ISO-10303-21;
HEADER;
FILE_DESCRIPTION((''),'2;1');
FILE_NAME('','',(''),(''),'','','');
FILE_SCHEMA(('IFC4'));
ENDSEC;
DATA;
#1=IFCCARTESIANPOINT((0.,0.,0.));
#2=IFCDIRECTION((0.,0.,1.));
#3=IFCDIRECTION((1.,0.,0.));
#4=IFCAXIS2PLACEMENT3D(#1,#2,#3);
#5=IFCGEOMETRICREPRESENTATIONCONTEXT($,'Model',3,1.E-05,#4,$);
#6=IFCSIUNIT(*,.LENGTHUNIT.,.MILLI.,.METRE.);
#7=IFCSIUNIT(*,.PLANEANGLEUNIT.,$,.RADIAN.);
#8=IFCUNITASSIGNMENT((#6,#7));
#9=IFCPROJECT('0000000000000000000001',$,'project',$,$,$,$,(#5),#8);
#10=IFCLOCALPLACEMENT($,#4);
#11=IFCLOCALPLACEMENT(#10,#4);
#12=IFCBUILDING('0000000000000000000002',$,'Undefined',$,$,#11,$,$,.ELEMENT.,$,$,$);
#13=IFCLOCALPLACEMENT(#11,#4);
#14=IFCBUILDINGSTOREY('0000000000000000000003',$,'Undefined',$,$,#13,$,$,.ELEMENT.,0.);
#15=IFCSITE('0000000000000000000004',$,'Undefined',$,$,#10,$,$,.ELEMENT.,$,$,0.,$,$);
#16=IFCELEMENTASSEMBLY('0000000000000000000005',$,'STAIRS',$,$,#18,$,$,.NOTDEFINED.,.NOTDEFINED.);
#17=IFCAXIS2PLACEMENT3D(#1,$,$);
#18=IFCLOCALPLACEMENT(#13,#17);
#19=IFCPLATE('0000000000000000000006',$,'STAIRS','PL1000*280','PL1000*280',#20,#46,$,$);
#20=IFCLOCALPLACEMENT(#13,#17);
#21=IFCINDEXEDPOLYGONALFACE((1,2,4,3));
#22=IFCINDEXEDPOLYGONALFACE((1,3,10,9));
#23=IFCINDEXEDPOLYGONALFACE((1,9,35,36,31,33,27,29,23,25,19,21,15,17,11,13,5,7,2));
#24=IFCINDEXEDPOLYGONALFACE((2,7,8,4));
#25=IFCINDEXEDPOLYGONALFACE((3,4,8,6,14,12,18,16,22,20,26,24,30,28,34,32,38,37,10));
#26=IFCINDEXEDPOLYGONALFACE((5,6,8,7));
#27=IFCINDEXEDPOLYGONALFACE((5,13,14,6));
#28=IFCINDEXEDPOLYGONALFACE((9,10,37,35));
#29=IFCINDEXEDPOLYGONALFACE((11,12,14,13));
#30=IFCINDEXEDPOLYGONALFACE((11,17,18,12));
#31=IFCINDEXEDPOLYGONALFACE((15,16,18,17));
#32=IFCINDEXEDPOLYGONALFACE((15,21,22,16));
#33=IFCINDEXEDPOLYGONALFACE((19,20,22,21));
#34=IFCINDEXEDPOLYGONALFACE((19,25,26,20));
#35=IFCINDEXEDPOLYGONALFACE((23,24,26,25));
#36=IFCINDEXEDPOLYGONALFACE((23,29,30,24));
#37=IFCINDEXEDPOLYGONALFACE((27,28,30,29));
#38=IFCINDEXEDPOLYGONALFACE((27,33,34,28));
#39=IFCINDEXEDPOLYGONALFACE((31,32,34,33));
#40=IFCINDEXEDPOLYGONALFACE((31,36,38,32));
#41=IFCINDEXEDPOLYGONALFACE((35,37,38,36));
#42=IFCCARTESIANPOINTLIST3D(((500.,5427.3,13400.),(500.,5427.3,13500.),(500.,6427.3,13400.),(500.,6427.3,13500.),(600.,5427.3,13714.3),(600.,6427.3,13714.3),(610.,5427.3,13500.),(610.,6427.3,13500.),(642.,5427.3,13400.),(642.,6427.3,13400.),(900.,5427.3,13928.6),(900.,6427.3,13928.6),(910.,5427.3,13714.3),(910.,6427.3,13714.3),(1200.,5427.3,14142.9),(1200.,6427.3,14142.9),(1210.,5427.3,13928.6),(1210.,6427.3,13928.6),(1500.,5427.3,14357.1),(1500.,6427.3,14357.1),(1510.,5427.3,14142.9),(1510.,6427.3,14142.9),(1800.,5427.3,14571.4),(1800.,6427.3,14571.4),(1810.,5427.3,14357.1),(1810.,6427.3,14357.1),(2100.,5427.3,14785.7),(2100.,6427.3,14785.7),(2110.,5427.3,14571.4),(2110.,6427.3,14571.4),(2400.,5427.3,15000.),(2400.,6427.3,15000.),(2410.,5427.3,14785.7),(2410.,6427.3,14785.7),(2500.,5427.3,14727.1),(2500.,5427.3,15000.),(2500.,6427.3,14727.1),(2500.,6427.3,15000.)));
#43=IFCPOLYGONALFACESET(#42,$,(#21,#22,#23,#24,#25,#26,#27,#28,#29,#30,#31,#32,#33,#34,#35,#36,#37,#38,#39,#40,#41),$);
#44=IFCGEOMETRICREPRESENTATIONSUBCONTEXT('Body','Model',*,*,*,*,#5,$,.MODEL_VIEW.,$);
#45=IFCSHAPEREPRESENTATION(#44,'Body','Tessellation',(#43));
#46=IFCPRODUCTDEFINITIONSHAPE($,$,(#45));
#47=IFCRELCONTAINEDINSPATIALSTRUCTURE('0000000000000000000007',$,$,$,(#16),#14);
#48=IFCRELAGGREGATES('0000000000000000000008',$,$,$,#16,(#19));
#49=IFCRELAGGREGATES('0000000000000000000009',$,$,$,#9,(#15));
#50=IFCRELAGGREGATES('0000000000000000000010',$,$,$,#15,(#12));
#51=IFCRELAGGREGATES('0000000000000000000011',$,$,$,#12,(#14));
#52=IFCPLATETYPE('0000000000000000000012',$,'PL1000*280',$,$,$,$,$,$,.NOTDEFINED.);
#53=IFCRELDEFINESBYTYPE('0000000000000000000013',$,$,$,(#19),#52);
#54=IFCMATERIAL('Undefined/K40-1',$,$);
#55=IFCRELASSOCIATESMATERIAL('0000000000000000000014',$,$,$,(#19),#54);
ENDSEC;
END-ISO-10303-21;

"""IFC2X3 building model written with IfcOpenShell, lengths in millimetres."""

from ifc_helpers import new_model, si_unit, frame, origin_with_axes, place, context, subcontext, project, spatial, polyline, outline, extrude, material, type_object, element, aggregate, save


model = new_model("IFC2X3")

# Units and contexts
model_context = context("Model", 3, precision=1e-05, world=origin_with_axes())
body_context = subcontext(model_context, "Body", "Model", "MODEL_VIEW")
ifc_project = project(units=[si_unit("LENGTHUNIT", "METRE", prefix="MILLI"), si_unit("PLANEANGLEUNIT", "RADIAN")], contexts=[model_context])

# Site, building, storey
site_placement = place(None, origin_with_axes())
site = spatial("IfcSite", under=ifc_project, at=site_placement, Name="Undefined", CompositionType="ELEMENT", RefElevation=0.0)
building_placement = place(site_placement, origin_with_axes())
building = spatial("IfcBuilding", under=site, at=building_placement, Name="Undefined", CompositionType="ELEMENT")
storey_placement = place(building_placement, origin_with_axes())
storey = spatial("IfcBuildingStorey", under=building, at=storey_placement, Name="Undefined", CompositionType="ELEMENT", Elevation=0.0)

# Element assembly, plate
ifc_material_1 = material(Name="Undefined/K40-1")
plate_type_1 = type_object("IfcPlateType", Name="PL1000*280", PredefinedType="NOTDEFINED")
assembly_1_placement = place(storey_placement, origin_with_axes())
assembly_1 = element("IfcElementAssembly", 1, at=assembly_1_placement, inside=storey, Name="STAIRS", AssemblyPlace="NOTDEFINED", PredefinedType="NOTDEFINED")
plate_1_placement = place(assembly_1_placement, frame((610.0, 5927.3, 13500.0), z_axis=(0.0, -1.0, 0.0), x_axis=(-1.0, 0.0, 0.0)))
plate_1 = element("IfcPlate", 2, at=plate_1_placement, type_object=plate_type_1, material=ifc_material_1, Name="STAIRS", Description="PL1000*280", ObjectType="PL1000*280", context=body_context, shape_type="SweptSolid", body=[
    extrude(outline(polyline([(0.0, 0.0), (110.0, 0.0), (110.0, 100.0), (-32.0, 100.0), (-1890.0, -1227.1), (-1890.0, -1500.0), (-1790.0, -1500.0), (-1800.0, -1285.7), (-1490.0, -1285.7), (-1500.0, -1071.4), (-1190.0, -1071.4), (-1200.0, -857.1), (-890.0, -857.1), (-900.0, -642.9), (-590.0, -642.9), (-600.0, -428.6), (-290.0, -428.6), (-300.0, -214.3), (10.0, -214.3), (0.0, 0.0), (0.0, 0.0)])), frame((0.0, 0.0, -500.0), z_axis=(0.0, 0.0, 1.0), x_axis=(1.0, 0.0, 0.0)), (0.0, 0.0, 1.0), 1000.0),
])
aggregate(assembly_1, [plate_1])

save(model, "model.ifc")
